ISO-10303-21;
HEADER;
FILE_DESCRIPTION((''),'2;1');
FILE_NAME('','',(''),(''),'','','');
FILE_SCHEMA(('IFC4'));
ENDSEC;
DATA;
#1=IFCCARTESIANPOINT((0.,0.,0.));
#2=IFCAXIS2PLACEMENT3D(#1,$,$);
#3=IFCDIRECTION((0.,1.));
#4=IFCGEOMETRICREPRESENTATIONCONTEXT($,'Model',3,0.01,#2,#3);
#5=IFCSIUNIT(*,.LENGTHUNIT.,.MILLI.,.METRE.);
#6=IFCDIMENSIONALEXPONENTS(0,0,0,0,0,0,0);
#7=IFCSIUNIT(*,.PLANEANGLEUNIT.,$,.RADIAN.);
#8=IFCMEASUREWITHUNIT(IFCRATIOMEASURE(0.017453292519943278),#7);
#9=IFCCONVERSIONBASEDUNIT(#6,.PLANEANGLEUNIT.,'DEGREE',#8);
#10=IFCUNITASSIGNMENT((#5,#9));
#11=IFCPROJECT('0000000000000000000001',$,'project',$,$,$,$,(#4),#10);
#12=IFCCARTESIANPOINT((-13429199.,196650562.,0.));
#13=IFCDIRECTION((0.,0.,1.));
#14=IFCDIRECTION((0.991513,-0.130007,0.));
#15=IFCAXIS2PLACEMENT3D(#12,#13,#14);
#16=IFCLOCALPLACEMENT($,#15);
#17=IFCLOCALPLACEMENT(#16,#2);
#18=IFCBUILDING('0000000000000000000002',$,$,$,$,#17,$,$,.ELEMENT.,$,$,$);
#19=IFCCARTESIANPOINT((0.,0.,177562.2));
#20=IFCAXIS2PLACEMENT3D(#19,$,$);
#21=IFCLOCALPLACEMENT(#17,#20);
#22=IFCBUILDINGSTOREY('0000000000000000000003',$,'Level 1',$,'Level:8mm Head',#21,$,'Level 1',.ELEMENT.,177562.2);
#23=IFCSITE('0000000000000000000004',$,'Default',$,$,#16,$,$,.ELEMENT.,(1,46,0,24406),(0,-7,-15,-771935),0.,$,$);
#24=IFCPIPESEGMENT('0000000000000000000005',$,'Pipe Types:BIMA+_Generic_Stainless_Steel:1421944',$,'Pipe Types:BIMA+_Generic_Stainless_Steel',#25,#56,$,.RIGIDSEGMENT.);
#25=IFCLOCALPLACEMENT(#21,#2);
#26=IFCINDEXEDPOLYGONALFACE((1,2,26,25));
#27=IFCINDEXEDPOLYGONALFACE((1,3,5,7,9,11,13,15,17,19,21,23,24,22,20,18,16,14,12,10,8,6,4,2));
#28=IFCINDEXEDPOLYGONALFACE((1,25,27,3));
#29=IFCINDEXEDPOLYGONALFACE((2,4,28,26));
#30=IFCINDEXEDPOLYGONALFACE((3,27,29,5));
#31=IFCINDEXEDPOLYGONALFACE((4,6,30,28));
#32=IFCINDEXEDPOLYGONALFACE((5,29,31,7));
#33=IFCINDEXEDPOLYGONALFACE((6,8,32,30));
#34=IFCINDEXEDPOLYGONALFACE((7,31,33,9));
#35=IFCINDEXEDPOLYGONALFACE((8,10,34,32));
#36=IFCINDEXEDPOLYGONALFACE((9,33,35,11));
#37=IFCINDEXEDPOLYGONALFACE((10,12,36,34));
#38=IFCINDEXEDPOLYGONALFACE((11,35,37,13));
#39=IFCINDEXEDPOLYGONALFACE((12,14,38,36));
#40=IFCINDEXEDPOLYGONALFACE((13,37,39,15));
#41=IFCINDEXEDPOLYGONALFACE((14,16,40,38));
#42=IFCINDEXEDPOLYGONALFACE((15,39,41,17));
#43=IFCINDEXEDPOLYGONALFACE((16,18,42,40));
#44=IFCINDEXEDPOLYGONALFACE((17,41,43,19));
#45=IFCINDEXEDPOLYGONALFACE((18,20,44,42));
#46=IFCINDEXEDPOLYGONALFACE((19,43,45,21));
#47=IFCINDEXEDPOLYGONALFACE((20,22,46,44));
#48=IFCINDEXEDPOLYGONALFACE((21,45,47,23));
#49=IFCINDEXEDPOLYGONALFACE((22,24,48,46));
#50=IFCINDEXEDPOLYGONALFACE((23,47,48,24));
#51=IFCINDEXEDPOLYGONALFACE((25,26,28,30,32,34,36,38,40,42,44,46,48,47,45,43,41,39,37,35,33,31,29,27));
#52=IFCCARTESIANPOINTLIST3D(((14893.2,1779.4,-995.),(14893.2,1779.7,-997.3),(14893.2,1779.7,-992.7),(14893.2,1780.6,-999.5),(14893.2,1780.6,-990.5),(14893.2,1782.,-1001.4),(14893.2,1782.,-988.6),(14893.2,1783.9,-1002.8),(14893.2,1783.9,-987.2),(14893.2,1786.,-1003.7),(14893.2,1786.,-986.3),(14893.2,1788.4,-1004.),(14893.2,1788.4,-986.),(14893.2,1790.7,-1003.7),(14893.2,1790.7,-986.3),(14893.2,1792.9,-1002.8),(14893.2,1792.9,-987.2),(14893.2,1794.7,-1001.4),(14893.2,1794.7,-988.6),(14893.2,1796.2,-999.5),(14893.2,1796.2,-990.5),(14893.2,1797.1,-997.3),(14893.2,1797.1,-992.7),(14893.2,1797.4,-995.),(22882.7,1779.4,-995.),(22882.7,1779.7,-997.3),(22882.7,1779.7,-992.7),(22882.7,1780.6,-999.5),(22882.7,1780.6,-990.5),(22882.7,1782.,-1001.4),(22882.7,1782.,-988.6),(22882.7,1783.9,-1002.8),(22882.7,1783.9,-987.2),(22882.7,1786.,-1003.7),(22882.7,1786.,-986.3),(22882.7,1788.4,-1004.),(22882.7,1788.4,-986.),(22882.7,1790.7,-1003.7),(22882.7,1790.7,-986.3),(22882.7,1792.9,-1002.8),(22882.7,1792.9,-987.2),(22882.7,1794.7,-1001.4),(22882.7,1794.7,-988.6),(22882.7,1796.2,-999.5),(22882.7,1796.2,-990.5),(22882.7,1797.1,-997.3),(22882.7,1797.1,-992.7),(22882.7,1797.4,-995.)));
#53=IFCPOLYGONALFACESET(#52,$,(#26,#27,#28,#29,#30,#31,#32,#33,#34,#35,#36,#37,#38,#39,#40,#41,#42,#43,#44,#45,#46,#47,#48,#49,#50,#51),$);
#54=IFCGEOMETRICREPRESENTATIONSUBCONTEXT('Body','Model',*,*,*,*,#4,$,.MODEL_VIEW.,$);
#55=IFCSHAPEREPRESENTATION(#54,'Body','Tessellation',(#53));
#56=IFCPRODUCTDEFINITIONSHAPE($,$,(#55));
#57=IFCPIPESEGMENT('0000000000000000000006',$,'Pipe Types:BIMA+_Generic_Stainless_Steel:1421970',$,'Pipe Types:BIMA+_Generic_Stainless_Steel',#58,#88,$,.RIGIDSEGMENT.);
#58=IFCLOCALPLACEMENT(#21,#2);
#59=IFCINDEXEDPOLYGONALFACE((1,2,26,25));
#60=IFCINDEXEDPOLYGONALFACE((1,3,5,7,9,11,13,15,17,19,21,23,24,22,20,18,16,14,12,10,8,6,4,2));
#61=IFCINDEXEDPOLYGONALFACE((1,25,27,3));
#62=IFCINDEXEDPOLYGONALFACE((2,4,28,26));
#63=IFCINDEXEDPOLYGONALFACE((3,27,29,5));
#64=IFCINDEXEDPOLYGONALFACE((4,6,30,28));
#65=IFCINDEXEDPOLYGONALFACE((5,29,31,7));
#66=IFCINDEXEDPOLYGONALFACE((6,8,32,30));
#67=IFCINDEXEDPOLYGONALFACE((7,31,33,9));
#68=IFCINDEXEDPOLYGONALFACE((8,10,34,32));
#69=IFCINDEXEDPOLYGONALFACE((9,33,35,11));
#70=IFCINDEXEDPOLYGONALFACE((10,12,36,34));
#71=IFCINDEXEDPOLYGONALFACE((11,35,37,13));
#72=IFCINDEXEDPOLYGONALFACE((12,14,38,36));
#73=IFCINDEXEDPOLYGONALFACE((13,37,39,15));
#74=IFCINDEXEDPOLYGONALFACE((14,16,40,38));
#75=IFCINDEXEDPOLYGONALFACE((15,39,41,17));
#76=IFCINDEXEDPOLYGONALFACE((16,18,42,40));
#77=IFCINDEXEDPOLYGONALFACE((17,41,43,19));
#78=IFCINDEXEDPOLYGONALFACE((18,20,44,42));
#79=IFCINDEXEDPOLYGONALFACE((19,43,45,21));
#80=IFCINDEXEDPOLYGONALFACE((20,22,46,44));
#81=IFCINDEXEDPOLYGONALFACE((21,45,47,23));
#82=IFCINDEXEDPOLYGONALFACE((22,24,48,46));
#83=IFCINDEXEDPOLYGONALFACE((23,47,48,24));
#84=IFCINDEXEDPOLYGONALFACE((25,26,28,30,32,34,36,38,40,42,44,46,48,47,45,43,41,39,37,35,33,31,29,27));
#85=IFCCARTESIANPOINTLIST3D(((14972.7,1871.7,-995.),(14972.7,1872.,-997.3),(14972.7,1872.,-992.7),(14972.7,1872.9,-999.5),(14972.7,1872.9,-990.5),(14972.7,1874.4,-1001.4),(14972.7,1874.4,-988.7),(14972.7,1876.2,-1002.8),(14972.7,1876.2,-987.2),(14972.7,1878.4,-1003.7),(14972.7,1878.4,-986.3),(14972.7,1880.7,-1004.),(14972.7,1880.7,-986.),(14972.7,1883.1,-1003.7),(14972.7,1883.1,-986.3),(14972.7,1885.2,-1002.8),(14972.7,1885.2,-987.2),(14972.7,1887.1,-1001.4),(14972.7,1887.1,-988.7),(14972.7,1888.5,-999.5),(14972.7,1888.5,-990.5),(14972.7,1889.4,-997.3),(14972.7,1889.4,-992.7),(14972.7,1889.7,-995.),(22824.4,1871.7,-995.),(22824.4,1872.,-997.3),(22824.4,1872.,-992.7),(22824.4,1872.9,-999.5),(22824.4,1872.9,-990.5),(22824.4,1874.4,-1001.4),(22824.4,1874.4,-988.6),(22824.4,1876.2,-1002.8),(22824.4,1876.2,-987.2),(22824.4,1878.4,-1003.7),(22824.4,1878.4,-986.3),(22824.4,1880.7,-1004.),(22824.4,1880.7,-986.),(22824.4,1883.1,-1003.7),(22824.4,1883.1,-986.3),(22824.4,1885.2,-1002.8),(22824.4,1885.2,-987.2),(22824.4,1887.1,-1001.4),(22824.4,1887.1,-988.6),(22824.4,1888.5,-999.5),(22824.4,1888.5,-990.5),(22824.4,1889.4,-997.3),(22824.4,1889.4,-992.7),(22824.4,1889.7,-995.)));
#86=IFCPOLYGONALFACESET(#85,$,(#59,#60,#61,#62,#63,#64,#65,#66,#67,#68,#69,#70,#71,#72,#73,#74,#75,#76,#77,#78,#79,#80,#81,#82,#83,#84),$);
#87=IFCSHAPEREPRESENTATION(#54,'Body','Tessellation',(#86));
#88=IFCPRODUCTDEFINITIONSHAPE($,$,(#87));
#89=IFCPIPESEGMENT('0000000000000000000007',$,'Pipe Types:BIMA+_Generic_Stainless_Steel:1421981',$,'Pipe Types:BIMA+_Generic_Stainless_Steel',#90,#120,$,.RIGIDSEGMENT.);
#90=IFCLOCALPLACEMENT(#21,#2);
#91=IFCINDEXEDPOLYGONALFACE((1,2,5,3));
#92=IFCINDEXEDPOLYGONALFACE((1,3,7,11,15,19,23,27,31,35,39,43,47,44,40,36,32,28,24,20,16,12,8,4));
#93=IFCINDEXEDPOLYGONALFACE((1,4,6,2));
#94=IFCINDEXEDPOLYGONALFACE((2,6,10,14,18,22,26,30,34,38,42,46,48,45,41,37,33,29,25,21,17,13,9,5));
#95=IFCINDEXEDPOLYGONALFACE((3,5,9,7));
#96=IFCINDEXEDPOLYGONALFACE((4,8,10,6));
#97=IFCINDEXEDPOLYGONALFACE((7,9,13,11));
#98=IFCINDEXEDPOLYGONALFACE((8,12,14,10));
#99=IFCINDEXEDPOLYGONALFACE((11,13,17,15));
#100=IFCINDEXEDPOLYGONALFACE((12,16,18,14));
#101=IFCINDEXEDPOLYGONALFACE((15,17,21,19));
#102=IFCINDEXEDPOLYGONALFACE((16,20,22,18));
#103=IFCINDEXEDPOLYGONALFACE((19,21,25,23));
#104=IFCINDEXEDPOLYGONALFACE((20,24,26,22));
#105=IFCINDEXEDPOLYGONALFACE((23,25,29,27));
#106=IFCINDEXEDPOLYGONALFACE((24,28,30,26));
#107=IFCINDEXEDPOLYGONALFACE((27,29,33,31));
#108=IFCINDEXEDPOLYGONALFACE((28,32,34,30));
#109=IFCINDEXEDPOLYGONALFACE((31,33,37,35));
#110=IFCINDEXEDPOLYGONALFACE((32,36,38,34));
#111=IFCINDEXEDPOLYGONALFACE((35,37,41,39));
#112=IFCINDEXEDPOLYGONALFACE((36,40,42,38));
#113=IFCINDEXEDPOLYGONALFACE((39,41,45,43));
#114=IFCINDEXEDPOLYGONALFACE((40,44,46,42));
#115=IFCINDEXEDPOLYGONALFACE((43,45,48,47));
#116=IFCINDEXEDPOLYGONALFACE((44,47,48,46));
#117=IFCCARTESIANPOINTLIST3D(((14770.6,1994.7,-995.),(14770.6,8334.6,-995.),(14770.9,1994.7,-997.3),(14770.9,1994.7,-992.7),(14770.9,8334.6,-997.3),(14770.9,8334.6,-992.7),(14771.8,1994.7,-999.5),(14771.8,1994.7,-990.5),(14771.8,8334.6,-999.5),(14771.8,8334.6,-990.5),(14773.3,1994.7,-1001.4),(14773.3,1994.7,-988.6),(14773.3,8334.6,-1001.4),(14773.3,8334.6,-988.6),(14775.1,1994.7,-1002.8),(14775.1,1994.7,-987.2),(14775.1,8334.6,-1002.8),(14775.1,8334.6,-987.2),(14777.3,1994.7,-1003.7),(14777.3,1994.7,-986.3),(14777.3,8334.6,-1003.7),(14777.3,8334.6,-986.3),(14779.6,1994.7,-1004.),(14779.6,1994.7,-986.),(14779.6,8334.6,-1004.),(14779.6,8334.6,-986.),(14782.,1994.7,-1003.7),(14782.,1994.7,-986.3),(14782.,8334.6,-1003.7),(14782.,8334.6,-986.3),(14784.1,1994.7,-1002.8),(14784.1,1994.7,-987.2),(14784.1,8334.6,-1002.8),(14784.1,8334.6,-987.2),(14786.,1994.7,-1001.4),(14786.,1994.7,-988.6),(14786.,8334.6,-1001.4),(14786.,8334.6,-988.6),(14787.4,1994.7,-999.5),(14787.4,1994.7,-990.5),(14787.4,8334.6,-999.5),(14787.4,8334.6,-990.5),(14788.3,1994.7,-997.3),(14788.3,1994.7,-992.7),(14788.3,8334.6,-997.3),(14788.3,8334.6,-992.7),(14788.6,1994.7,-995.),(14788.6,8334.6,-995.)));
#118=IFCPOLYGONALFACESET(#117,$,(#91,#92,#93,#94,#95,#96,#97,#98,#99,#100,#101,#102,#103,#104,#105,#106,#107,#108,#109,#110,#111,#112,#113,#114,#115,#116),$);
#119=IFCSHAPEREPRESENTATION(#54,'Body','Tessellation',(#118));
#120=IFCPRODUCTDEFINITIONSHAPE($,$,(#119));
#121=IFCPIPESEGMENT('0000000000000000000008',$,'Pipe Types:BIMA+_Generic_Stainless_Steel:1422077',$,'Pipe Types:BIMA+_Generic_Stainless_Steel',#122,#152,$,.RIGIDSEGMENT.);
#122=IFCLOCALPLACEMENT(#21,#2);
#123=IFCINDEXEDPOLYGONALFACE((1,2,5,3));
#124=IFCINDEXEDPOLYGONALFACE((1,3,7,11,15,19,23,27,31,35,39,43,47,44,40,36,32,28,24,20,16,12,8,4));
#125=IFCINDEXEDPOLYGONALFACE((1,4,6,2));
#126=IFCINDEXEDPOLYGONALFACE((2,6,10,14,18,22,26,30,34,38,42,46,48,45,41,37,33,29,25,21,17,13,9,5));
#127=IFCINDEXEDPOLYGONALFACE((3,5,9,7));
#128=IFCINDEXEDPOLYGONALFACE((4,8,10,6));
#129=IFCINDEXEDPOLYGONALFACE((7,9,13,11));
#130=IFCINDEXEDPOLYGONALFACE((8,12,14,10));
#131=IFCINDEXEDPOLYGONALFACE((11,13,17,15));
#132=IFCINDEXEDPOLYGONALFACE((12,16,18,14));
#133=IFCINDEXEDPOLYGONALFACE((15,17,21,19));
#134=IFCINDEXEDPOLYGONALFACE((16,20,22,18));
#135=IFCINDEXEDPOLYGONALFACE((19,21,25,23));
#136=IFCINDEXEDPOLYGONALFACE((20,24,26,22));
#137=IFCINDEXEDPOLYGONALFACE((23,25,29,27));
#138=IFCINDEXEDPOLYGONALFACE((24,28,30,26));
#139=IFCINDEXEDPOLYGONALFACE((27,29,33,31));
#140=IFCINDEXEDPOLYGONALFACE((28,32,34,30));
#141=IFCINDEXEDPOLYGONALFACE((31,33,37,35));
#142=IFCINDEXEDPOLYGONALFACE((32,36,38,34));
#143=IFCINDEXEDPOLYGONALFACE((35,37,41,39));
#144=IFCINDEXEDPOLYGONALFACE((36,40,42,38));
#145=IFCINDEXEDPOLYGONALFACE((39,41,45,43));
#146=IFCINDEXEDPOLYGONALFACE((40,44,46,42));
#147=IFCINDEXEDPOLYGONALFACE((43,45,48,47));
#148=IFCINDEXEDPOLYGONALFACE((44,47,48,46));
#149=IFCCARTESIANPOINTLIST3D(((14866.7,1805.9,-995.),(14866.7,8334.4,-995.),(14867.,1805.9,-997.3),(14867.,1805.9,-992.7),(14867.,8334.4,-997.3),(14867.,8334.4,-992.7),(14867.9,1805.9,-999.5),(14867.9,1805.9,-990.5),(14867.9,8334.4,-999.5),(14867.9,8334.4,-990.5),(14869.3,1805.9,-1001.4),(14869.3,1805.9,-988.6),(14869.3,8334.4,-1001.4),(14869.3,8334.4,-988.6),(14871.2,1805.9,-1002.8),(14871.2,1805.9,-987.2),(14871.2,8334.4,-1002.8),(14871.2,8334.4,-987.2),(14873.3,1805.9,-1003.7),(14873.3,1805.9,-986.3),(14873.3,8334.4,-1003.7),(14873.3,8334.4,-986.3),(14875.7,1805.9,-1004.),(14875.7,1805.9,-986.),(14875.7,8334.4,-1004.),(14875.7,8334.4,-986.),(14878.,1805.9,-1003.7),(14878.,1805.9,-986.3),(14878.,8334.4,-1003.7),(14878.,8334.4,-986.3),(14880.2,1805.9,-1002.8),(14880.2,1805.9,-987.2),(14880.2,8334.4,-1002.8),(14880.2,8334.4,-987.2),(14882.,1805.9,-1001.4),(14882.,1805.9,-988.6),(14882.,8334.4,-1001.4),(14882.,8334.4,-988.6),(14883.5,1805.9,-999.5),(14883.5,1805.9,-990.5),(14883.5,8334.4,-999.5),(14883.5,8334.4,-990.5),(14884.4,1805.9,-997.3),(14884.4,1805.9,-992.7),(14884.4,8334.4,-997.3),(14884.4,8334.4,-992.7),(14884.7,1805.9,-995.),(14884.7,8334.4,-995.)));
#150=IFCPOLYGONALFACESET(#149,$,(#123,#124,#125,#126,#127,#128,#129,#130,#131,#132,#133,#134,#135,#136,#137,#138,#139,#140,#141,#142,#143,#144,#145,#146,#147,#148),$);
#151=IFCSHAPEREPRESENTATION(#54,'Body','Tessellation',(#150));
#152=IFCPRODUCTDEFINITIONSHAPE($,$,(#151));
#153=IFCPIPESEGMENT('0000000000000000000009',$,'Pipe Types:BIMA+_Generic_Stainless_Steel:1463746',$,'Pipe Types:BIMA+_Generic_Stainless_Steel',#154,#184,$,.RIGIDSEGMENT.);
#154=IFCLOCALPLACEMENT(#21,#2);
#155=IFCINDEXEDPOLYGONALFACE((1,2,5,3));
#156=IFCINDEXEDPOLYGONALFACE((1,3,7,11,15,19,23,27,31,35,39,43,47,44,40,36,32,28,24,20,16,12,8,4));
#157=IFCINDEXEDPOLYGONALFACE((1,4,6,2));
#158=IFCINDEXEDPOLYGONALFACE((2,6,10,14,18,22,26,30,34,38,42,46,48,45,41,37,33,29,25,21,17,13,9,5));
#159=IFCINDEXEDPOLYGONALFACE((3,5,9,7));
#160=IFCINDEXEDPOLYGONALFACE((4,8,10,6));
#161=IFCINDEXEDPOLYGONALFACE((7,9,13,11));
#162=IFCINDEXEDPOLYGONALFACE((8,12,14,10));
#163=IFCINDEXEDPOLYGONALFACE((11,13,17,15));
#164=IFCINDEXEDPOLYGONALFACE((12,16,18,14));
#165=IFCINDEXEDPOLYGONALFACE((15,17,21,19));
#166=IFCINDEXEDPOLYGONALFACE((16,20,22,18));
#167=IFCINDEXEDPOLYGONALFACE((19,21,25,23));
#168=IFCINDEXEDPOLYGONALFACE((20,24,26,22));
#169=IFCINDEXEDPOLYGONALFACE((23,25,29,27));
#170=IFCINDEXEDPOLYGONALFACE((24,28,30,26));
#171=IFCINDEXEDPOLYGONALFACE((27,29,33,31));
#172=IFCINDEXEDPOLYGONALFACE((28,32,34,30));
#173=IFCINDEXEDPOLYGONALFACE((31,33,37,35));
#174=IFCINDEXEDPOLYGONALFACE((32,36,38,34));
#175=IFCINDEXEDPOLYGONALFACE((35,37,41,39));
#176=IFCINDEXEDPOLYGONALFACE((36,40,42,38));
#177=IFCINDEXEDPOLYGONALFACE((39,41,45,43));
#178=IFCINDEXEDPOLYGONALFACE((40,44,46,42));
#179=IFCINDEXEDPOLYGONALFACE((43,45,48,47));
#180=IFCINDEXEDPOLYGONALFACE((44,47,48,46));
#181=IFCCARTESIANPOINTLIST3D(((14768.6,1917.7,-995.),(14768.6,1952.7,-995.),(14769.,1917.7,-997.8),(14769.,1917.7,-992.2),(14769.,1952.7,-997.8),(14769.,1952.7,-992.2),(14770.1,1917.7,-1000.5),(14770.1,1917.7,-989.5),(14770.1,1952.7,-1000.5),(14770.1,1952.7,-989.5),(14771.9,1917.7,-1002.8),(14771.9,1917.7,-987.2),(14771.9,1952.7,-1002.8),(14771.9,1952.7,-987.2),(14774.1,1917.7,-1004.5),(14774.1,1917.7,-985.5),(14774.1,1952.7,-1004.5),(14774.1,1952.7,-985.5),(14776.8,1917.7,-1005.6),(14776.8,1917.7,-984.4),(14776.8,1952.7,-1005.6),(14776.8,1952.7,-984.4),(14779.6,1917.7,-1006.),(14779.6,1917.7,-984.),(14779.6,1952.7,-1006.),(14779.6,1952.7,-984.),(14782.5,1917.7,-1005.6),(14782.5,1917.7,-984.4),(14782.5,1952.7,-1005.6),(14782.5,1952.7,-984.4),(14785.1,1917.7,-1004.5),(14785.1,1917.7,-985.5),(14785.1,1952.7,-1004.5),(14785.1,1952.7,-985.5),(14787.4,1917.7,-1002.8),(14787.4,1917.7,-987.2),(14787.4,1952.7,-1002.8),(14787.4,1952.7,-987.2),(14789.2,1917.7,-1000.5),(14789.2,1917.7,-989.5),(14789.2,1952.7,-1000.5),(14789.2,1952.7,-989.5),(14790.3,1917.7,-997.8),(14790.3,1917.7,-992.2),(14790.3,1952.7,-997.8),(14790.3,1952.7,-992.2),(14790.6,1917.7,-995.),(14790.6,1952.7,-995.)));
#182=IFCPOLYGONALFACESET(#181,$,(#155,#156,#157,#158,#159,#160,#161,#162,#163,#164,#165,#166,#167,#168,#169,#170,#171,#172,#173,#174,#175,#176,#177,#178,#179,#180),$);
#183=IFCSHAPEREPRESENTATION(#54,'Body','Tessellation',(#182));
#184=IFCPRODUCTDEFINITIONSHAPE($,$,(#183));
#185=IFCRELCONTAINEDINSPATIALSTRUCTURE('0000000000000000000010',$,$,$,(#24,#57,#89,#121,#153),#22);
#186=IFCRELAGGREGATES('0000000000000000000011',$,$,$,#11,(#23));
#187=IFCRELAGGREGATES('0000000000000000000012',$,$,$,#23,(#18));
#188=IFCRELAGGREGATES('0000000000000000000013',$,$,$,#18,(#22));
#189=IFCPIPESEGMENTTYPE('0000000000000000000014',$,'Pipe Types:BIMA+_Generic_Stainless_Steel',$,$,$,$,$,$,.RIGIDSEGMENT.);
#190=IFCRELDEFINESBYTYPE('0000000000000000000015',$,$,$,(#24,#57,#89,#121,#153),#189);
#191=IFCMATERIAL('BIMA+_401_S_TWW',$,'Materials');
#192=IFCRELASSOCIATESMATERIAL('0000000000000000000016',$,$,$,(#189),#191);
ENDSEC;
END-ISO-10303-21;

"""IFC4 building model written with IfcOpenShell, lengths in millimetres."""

from ifc_helpers import new_model, entity, si_unit, converted_unit, direction, frame, origin, place, context, subcontext, project, spatial, arc, indexed_curve, outline, extrude, material, type_object, element, save


model = new_model("IFC4")

# Units and contexts
model_context = context("Model", 3, precision=0.01, world=origin(), true_north=direction((0.0, 1.0)))
body_context = subcontext(model_context, "Body", "Model", "MODEL_VIEW")
ifc_project = project(units=[si_unit("LENGTHUNIT", "METRE", prefix="MILLI"), converted_unit("PLANEANGLEUNIT", "DEGREE", entity("IfcRatioMeasure", 0.017453292519943278), si_unit("PLANEANGLEUNIT", "RADIAN"), dimensions=[0, 0, 0, 0, 0, 0, 0])], contexts=[model_context])

# Site, building, storey
site_placement = place(None, frame((-13429199.0, 196650562.0, 0.0), z_axis=(0.0, 0.0, 1.0), x_axis=(0.991513, -0.130007, 0.0)))
site = spatial("IfcSite", under=ifc_project, at=site_placement, Name="Default", CompositionType="ELEMENT", RefLatitude=(1, 46, 0, 24406), RefLongitude=(0, -7, -15, -771935), RefElevation=0.0)
building_placement = place(site_placement, origin())
building = spatial("IfcBuilding", under=site, at=building_placement, CompositionType="ELEMENT")
storey_placement = place(building_placement, frame((0.0, 0.0, 177562.2)))
storey = spatial("IfcBuildingStorey", under=building, at=storey_placement, Name="Level 1", ObjectType="Level:8mm Head", LongName="Level 1", CompositionType="ELEMENT", Elevation=177562.2)

# Pipe segments
ifc_material_1 = material(Name="BIMA+_401_S_TWW", Category="Materials")
pipe_segment_type_1 = type_object("IfcPipeSegmentType", Name="Pipe Types:BIMA+_Generic_Stainless_Steel", PredefinedType="RIGIDSEGMENT", material=ifc_material_1)
pipe_segment_1_placement = place(storey_placement, frame((14893.2, 1777.8, -1005.6)))
element("IfcPipeSegment", 1, at=pipe_segment_1_placement, inside=storey, type_object=pipe_segment_type_1, Name="Pipe Types:BIMA+_Generic_Stainless_Steel:1421944", ObjectType="Pipe Types:BIMA+_Generic_Stainless_Steel", PredefinedType="RIGIDSEGMENT", context=body_context, shape_type="SweptSolid", body=[
    extrude(outline(indexed_curve([(9.0, 0.0), (6.4, 6.4), (0.0, 9.0), (-6.4, 6.4), (-9.0, 0.0), (-6.4, -6.4), (0.0, -9.0), (6.4, -6.4)], segments=[arc(1, 2, 3), arc(3, 4, 5), arc(5, 6, 7), arc(7, 8, 1)], self_intersect=False)), frame((0.0, 10.6, 10.6), z_axis=(1.0, 0.0, 0.0), x_axis=(0.0, -1.0, 0.0)), (0.0, 0.0, 1.0), 7989.5),
])
pipe_segment_2_placement = place(storey_placement, frame((14972.7, 1870.1, -1005.6)))
element("IfcPipeSegment", 2, at=pipe_segment_2_placement, inside=storey, type_object=pipe_segment_type_1, Name="Pipe Types:BIMA+_Generic_Stainless_Steel:1421970", ObjectType="Pipe Types:BIMA+_Generic_Stainless_Steel", PredefinedType="RIGIDSEGMENT", context=body_context, shape_type="SweptSolid", body=[
    extrude(outline(indexed_curve([(9.0, 0.0), (6.4, 6.4), (0.0, 9.0), (-6.4, 6.4), (-9.0, 0.0), (-6.4, -6.4), (0.0, -9.0), (6.4, -6.4)], segments=[arc(1, 2, 3), arc(3, 4, 5), arc(5, 6, 7), arc(7, 8, 1)], self_intersect=False)), frame((0.0, 10.6, 10.6), z_axis=(1.0, 0.0, 0.000002), x_axis=(0.0, -1.0, 0.0)), (0.0, 0.0, 1.0), 7851.7),
])
pipe_segment_3_placement = place(storey_placement, frame((14769.0, 1994.7, -1005.6)))
element("IfcPipeSegment", 3, at=pipe_segment_3_placement, inside=storey, type_object=pipe_segment_type_1, Name="Pipe Types:BIMA+_Generic_Stainless_Steel:1421981", ObjectType="Pipe Types:BIMA+_Generic_Stainless_Steel", PredefinedType="RIGIDSEGMENT", context=body_context, shape_type="SweptSolid", body=[
    extrude(outline(indexed_curve([(9.0, 0.0), (6.4, 6.4), (0.0, 9.0), (-6.4, 6.4), (-9.0, 0.0), (-6.4, -6.4), (0.0, -9.0), (6.4, -6.4)], segments=[arc(1, 2, 3), arc(3, 4, 5), arc(5, 6, 7), arc(7, 8, 1)], self_intersect=False)), frame((10.6, 0.0, 10.6), z_axis=(0.0, 1.0, 0.0), x_axis=(1.0, 0.0, 0.0)), (0.0, 0.0, 1.0), 6340.0),
])
pipe_segment_4_placement = place(storey_placement, frame((14865.1, 1805.9, -1005.6)))
element("IfcPipeSegment", 4, at=pipe_segment_4_placement, inside=storey, type_object=pipe_segment_type_1, Name="Pipe Types:BIMA+_Generic_Stainless_Steel:1422077", ObjectType="Pipe Types:BIMA+_Generic_Stainless_Steel", PredefinedType="RIGIDSEGMENT", context=body_context, shape_type="SweptSolid", body=[
    extrude(outline(indexed_curve([(9.0, 0.0), (6.4, 6.4), (0.0, 9.0), (-6.4, 6.4), (-9.0, 0.0), (-6.4, -6.4), (0.0, -9.0), (6.4, -6.4)], segments=[arc(1, 2, 3), arc(3, 4, 5), arc(5, 6, 7), arc(7, 8, 1)], self_intersect=False)), frame((10.6, 0.0, 10.6), z_axis=(0.0, 1.0, 0.0), x_axis=(1.0, 0.0, 0.0)), (0.0, 0.0, 1.0), 6528.6),
])
pipe_segment_5_placement = place(storey_placement, frame((14767.0, 1917.7, -1007.6)))
element("IfcPipeSegment", 5, at=pipe_segment_5_placement, inside=storey, type_object=pipe_segment_type_1, Name="Pipe Types:BIMA+_Generic_Stainless_Steel:1463746", ObjectType="Pipe Types:BIMA+_Generic_Stainless_Steel", PredefinedType="RIGIDSEGMENT", context=body_context, shape_type="SweptSolid", body=[
    extrude(outline(indexed_curve([(11.0, 0.0), (7.8, 7.8), (0.0, 11.0), (-7.8, 7.8), (-11.0, 0.0), (-7.8, -7.8), (0.0, -11.0), (7.8, -7.8)], segments=[arc(1, 2, 3), arc(3, 4, 5), arc(5, 6, 7), arc(7, 8, 1)], self_intersect=False)), frame((12.6, 0.0, 12.6), z_axis=(0.0, 1.0, 0.0), x_axis=(-1.0, 0.0, 0.0)), (0.0, 0.0, 1.0), 35.0),
])

save(model, "model.ifc")
